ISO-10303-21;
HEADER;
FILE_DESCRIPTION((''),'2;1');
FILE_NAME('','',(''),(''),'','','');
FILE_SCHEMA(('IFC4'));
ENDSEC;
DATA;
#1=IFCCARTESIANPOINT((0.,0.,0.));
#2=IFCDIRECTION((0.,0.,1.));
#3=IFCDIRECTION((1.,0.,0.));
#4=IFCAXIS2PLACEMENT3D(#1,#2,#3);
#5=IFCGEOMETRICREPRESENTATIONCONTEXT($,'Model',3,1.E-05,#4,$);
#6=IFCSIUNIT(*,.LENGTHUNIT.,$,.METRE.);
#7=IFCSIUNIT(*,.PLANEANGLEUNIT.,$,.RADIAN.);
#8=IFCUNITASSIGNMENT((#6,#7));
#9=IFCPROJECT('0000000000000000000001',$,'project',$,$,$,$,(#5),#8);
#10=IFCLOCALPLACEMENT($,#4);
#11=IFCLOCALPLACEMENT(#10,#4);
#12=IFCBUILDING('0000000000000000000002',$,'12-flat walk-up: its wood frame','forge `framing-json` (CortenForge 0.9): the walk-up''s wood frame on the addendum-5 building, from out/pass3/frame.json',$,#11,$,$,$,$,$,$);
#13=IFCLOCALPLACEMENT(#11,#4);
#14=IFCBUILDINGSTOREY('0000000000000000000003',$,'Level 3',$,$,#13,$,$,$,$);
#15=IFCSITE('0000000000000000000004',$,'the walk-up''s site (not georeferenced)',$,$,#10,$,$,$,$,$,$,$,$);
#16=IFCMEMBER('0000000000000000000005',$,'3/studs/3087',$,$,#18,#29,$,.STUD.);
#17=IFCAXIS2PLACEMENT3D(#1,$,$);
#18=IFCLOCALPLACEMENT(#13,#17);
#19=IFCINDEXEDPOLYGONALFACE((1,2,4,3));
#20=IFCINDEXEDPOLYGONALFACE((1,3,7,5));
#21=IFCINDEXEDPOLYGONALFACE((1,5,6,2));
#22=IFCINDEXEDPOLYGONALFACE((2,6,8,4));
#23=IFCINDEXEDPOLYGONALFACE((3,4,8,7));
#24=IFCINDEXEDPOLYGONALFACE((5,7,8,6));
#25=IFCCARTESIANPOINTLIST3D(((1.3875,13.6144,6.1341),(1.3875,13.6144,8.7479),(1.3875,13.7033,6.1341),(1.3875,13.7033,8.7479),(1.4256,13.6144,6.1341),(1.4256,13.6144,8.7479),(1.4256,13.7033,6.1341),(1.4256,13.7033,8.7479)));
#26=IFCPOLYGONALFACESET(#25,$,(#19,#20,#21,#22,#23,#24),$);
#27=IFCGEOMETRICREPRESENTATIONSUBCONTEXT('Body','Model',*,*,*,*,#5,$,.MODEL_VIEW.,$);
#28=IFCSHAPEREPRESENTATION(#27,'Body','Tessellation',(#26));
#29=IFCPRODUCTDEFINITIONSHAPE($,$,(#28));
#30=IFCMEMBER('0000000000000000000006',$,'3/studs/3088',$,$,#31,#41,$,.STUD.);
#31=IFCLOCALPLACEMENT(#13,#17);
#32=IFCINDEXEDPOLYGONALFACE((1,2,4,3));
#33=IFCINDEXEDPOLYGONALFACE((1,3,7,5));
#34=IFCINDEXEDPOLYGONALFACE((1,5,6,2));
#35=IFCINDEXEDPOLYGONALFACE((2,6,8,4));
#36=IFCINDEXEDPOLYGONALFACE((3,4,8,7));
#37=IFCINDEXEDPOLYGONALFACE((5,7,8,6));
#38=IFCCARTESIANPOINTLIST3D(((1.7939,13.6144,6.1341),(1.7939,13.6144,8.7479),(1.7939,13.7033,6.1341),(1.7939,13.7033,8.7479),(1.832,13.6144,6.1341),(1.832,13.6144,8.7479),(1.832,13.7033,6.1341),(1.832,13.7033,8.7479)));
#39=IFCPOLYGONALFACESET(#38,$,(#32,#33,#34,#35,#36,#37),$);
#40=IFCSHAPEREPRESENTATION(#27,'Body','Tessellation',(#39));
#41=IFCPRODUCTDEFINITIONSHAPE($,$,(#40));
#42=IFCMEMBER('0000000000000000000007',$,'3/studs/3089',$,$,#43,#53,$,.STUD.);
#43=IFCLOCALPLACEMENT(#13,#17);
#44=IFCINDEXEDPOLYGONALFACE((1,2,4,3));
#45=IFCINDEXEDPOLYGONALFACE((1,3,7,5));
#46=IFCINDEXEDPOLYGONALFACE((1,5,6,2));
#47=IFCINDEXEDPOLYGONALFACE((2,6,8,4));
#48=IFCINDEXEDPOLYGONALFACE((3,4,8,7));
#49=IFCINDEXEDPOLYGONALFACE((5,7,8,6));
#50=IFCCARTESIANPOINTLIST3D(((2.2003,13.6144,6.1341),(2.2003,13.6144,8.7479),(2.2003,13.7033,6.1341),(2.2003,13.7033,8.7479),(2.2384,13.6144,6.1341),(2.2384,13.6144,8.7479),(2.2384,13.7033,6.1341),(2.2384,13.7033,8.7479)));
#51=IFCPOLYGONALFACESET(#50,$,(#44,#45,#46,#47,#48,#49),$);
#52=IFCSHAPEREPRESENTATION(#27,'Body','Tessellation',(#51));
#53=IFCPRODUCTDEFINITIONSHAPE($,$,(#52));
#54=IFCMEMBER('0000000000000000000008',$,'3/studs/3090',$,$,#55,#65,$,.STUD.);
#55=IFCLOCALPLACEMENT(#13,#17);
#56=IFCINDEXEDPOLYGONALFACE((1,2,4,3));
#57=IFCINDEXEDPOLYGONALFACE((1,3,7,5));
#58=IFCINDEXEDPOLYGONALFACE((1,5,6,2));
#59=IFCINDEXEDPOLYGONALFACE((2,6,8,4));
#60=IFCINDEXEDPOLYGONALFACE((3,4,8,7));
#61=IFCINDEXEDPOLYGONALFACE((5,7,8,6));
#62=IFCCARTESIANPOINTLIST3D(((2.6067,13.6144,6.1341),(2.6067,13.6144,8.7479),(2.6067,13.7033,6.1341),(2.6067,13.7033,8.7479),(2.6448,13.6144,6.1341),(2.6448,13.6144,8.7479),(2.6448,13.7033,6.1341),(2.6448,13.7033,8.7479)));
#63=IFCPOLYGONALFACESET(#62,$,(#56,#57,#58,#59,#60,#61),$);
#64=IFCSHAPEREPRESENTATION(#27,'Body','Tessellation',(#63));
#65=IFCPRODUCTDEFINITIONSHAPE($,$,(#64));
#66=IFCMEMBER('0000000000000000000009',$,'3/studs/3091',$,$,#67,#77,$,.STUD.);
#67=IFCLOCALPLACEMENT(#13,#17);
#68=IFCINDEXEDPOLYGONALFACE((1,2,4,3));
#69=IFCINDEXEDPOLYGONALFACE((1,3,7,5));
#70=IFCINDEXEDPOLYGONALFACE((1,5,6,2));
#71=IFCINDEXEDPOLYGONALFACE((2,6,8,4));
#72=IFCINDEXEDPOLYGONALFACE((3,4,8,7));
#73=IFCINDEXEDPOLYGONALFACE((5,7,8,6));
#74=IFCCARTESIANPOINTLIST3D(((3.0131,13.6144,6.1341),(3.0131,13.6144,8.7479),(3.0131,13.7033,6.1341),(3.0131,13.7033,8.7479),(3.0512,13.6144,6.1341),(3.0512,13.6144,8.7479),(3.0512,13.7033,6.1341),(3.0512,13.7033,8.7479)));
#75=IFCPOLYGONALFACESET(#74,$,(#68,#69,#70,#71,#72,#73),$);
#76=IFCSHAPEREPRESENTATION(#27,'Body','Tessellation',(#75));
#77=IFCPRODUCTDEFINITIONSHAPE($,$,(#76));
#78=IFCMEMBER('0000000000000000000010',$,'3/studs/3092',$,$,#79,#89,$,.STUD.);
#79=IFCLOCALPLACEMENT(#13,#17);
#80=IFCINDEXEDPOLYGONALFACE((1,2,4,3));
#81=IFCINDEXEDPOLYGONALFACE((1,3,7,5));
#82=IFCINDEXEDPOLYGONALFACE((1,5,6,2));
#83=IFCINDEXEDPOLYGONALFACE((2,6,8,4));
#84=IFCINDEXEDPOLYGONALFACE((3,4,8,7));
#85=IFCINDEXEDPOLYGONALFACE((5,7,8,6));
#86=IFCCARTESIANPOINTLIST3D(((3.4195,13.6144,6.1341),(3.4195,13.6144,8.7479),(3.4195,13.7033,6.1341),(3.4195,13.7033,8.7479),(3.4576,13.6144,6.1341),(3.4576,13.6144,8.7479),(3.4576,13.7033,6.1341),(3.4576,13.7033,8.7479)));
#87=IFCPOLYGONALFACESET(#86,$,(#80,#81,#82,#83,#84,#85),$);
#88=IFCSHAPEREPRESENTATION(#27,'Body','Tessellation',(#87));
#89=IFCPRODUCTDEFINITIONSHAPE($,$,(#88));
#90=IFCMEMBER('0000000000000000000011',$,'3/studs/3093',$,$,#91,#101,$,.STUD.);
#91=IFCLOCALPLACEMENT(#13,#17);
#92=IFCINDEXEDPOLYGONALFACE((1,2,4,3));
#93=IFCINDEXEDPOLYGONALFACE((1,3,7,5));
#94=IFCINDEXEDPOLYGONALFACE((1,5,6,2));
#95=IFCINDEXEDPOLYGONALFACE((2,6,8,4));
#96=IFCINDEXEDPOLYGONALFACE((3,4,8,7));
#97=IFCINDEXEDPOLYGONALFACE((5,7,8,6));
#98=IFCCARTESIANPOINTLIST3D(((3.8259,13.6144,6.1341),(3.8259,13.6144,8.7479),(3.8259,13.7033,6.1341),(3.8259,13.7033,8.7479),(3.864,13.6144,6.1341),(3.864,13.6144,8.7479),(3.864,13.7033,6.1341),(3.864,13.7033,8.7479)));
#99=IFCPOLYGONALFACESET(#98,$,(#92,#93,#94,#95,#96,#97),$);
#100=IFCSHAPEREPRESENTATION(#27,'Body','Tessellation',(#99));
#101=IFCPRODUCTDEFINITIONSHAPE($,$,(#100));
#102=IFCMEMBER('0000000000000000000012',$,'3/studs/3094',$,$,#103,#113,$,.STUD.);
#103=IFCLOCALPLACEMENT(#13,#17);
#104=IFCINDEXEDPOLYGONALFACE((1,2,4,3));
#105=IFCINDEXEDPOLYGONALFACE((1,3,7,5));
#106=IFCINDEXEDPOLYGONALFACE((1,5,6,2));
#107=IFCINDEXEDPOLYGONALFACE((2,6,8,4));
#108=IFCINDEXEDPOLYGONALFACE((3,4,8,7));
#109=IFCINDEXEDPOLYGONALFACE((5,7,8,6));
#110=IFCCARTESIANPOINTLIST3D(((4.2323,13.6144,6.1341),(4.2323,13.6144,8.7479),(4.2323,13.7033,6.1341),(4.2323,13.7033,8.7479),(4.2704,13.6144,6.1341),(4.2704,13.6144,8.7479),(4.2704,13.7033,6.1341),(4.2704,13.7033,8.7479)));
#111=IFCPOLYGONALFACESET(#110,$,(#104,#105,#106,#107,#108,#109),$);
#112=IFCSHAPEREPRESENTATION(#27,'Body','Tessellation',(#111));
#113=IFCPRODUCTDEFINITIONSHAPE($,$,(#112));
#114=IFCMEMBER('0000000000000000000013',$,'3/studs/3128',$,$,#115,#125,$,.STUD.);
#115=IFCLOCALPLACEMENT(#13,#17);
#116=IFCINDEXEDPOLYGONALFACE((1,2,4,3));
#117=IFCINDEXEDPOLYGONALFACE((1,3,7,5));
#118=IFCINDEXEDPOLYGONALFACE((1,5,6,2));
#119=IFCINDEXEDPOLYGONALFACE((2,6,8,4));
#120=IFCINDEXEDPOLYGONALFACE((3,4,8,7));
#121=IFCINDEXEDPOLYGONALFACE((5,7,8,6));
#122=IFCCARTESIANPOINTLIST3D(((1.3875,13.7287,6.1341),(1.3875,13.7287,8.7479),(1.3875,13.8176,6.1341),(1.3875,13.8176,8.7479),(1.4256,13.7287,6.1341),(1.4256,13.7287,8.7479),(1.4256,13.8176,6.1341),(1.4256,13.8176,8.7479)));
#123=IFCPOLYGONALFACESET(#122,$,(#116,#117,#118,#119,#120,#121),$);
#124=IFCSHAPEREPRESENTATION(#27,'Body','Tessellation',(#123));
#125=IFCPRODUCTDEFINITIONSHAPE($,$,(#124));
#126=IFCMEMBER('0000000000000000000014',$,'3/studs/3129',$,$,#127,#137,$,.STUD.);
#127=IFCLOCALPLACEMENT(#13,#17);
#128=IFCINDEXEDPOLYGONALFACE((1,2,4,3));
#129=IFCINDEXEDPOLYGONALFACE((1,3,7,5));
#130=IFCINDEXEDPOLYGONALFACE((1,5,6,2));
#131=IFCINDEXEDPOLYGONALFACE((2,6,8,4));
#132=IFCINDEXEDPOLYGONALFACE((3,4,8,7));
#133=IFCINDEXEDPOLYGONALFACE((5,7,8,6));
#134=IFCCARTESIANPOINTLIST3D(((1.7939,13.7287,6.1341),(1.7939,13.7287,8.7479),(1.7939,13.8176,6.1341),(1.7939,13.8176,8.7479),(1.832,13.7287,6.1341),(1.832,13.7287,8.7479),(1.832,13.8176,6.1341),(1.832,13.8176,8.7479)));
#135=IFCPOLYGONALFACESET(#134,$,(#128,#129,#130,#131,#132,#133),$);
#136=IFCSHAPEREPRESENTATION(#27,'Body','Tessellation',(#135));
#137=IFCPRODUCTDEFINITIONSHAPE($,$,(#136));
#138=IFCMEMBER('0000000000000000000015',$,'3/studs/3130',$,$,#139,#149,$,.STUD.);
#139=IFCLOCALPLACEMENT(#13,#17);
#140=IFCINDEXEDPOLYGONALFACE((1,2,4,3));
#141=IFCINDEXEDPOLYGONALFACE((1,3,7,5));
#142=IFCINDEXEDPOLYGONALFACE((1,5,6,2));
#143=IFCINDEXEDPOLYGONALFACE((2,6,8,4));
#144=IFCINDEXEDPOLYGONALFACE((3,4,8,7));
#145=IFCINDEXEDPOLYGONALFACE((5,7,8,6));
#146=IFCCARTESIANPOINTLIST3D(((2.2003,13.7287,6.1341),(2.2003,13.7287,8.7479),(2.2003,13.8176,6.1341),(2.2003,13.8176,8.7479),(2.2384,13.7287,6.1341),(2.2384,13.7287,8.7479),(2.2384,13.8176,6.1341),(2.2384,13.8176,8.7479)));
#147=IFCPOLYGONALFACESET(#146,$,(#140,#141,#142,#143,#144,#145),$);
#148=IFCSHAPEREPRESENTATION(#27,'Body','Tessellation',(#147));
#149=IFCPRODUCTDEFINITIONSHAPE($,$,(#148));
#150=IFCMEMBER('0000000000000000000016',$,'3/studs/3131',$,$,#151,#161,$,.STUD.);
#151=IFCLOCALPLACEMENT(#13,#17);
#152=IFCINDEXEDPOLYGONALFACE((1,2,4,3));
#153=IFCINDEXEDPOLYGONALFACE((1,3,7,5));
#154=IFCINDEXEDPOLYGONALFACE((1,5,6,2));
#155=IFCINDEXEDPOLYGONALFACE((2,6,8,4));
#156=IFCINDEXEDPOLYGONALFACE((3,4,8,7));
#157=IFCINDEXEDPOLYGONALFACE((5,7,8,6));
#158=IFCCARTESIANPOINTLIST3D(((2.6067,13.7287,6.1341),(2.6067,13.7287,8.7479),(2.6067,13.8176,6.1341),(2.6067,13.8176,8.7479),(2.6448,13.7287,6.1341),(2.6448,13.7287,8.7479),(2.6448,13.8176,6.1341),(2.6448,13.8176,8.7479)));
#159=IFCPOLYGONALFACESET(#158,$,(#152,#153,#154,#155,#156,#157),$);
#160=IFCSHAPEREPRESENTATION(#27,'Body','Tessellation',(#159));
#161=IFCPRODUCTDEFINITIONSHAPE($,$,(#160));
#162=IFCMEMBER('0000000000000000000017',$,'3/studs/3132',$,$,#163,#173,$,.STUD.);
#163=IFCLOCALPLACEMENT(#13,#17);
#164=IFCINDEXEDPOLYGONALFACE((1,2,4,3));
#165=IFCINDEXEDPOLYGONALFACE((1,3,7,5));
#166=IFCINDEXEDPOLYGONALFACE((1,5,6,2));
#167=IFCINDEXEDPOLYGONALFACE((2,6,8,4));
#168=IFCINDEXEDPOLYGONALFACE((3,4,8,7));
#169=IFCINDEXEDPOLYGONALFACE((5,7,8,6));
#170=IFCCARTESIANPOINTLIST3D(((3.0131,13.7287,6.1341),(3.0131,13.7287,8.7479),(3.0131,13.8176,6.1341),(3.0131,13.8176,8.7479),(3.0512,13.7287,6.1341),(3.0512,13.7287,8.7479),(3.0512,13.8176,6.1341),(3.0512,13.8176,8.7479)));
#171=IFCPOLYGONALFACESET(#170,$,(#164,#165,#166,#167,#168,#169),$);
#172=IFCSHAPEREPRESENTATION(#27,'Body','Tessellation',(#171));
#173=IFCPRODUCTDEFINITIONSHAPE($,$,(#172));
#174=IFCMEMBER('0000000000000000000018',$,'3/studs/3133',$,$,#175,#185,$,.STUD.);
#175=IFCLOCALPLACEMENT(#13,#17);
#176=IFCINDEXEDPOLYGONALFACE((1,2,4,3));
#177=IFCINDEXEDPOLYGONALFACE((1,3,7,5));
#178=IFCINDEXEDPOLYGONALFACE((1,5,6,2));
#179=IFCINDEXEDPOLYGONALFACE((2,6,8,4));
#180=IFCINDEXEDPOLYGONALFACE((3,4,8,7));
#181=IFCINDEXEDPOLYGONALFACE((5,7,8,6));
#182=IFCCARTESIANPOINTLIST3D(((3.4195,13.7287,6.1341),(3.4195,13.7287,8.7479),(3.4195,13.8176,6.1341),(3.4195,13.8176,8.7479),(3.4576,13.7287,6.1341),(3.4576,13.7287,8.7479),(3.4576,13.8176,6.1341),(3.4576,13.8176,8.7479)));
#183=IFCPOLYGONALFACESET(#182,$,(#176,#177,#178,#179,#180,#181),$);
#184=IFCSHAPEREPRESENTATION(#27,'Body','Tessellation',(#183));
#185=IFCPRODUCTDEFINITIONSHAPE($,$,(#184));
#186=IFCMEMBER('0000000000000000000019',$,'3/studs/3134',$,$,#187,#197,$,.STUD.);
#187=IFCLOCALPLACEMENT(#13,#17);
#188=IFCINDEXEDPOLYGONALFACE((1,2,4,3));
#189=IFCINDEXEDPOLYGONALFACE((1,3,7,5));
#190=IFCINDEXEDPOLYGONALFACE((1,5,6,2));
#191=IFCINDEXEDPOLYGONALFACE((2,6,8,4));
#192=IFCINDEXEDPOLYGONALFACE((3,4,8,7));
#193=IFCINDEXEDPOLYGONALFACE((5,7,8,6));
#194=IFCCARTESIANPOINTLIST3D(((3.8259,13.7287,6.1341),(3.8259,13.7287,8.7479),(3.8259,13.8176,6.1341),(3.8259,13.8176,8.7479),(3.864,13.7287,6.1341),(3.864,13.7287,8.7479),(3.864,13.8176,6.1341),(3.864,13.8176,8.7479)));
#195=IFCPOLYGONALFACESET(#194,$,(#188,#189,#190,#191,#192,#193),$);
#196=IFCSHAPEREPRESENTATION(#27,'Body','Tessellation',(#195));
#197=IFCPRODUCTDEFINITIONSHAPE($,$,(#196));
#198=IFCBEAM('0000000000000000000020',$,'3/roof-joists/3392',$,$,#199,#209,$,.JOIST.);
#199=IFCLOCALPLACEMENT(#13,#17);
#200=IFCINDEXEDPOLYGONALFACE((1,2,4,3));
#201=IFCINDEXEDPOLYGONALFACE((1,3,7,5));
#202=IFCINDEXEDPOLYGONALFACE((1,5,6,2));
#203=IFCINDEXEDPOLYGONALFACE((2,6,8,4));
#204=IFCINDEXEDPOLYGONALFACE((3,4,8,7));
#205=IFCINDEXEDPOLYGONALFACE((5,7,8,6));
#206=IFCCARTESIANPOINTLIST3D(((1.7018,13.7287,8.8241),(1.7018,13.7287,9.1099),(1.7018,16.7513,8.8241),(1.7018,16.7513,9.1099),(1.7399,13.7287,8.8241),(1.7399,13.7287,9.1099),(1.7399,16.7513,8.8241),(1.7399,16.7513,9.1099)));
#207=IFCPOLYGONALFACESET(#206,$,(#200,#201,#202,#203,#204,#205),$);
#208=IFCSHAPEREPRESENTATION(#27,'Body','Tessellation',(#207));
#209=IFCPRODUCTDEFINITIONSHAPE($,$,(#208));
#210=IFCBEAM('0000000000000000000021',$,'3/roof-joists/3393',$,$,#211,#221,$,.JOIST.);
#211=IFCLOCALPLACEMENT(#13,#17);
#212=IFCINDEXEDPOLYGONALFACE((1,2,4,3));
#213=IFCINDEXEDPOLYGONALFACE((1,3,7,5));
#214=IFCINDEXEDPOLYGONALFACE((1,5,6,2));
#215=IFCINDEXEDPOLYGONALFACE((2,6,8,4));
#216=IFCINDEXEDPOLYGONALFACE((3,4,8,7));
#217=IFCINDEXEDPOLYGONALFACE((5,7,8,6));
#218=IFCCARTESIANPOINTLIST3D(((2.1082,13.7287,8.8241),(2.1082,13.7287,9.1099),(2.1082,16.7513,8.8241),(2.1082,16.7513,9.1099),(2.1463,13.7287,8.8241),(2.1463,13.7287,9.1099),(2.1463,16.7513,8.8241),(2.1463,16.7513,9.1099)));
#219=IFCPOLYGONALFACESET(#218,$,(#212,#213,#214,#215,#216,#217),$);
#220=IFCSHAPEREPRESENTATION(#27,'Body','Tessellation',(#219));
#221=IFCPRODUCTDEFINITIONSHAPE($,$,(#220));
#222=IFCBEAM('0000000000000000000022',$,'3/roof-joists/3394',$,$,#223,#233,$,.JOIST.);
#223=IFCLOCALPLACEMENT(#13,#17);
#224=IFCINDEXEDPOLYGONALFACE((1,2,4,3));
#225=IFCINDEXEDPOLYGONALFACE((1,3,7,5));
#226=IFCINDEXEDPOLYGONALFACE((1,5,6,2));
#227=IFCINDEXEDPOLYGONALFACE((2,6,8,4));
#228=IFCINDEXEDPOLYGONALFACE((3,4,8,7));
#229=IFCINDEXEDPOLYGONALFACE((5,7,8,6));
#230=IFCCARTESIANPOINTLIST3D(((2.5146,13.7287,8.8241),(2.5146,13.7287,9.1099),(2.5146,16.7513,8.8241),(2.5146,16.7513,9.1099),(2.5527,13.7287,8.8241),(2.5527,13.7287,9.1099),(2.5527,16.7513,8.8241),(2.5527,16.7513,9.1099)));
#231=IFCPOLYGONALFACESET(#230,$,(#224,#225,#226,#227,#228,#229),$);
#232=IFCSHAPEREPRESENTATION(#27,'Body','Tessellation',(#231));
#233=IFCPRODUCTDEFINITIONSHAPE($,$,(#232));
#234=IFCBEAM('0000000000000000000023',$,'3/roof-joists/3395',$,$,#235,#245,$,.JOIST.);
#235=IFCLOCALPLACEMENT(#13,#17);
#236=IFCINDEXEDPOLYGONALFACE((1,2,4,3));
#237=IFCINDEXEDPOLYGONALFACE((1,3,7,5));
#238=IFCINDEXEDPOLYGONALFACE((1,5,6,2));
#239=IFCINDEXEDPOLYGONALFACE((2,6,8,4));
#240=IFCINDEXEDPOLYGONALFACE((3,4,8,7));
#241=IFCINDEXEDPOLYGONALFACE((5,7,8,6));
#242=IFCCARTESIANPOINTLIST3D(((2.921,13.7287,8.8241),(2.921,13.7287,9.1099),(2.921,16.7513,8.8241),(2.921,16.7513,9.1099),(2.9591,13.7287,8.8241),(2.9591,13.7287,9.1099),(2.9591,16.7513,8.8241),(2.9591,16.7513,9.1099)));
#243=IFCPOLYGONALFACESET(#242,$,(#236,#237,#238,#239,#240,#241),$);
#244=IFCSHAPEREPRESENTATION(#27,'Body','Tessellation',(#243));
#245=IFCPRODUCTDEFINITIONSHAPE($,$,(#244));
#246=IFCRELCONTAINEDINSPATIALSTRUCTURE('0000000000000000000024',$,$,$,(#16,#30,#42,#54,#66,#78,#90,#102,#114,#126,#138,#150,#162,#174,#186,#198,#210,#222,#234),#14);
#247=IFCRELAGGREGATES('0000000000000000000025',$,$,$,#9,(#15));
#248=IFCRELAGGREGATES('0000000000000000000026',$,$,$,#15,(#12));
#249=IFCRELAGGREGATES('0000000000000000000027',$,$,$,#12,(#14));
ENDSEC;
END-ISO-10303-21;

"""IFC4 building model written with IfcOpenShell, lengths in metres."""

from ifc_helpers import new_model, si_unit, frame, frame_2d, origin, origin_with_axes, place, context, subcontext, project, spatial, rectangle, extrude, element, save


model = new_model("IFC4")

# Units and contexts
model_context = context("Model", 3, precision=1e-05, world=origin_with_axes())
body_context = subcontext(model_context, "Body", "Model", "MODEL_VIEW")
ifc_project = project(units=[si_unit("LENGTHUNIT", "METRE"), si_unit("PLANEANGLEUNIT", "RADIAN")], contexts=[model_context])

# Site, building, storey
site_placement = place(None, origin_with_axes())
site = spatial("IfcSite", under=ifc_project, at=site_placement, Name="the walk-up's site (not georeferenced)")
building_placement = place(site_placement, origin_with_axes())
building = spatial("IfcBuilding", under=site, at=building_placement, Name="12-flat walk-up: its wood frame", Description="forge `framing-json` (CortenForge 0.9): the walk-up's wood frame on the addendum-5 building, from out/pass3/frame.json")
storey_placement = place(building_placement, origin_with_axes())
storey = spatial("IfcBuildingStorey", under=building, at=storey_placement, Name="Level 3")

# Members
member_1_placement = place(storey_placement, frame((1.3875, 13.6144, 6.1341), z_axis=(0.0, 0.0, 1.0), x_axis=(1.0, 0.0, 0.0)))
element("IfcMember", 1, at=member_1_placement, inside=storey, Name="3/studs/3087", PredefinedType="STUD", context=body_context, shape_type="SweptSolid", body=[
    extrude(rectangle(XDim=0.0381, YDim=0.0889, at=frame_2d((0.0191, 0.0445))), origin(), (0.0, 0.0, 1.0), 2.6138),
])
member_2_placement = place(storey_placement, frame((1.7939, 13.6144, 6.1341), z_axis=(0.0, 0.0, 1.0), x_axis=(1.0, 0.0, 0.0)))
element("IfcMember", 2, at=member_2_placement, inside=storey, Name="3/studs/3088", PredefinedType="STUD", context=body_context, shape_type="SweptSolid", body=[
    extrude(rectangle(XDim=0.0381, YDim=0.0889, at=frame_2d((0.019, 0.0445))), origin(), (0.0, 0.0, 1.0), 2.6138),
])
for number, where, z_axis, x_axis, name in (
    (3, (2.2003, 13.6144, 6.1341), (0.0, 0.0, 1.0), (1.0, 0.0, 0.0), "3/studs/3089"),
    (4, (2.6067, 13.6144, 6.1341), (0.0, 0.0, 1.0), (1.0, 0.0, 0.0), "3/studs/3090"),
    (5, (3.0131, 13.6144, 6.1341), (0.0, 0.0, 1.0), (1.0, 0.0, 0.0), "3/studs/3091"),
    (6, (3.4195, 13.6144, 6.1341), (0.0, 0.0, 1.0), (1.0, 0.0, 0.0), "3/studs/3092"),
    (7, (3.8259, 13.6144, 6.1341), (0.0, 0.0, 1.0), (1.0, 0.0, 0.0), "3/studs/3093"),
    (8, (4.2323, 13.6144, 6.1341), (0.0, 0.0, 1.0), (1.0, 0.0, 0.0), "3/studs/3094"),
    (9, (1.3875, 13.7287, 6.1341), (0.0, 0.0, 1.0), (1.0, 0.0, 0.0), "3/studs/3128"),
):
    element("IfcMember", number, at=place(storey_placement, frame(where, z_axis=z_axis, x_axis=x_axis)), inside=storey, Name=name, PredefinedType="STUD", context=body_context, shape_type="SweptSolid", body=[
        extrude(rectangle(XDim=0.0381, YDim=0.0889, at=frame_2d((0.0191, 0.0445))), origin(), (0.0, 0.0, 1.0), 2.6138),
    ])
member_3_placement = place(storey_placement, frame((1.7939, 13.7287, 6.1341), z_axis=(0.0, 0.0, 1.0), x_axis=(1.0, 0.0, 0.0)))
element("IfcMember", 10, at=member_3_placement, inside=storey, Name="3/studs/3129", PredefinedType="STUD", context=body_context, shape_type="SweptSolid", body=[
    extrude(rectangle(XDim=0.0381, YDim=0.0889, at=frame_2d((0.019, 0.0445))), origin(), (0.0, 0.0, 1.0), 2.6138),
])
for number, where, z_axis, x_axis, name in (
    (11, (2.2003, 13.7287, 6.1341), (0.0, 0.0, 1.0), (1.0, 0.0, 0.0), "3/studs/3130"),
    (12, (2.6067, 13.7287, 6.1341), (0.0, 0.0, 1.0), (1.0, 0.0, 0.0), "3/studs/3131"),
    (13, (3.0131, 13.7287, 6.1341), (0.0, 0.0, 1.0), (1.0, 0.0, 0.0), "3/studs/3132"),
    (14, (3.4195, 13.7287, 6.1341), (0.0, 0.0, 1.0), (1.0, 0.0, 0.0), "3/studs/3133"),
    (15, (3.8259, 13.7287, 6.1341), (0.0, 0.0, 1.0), (1.0, 0.0, 0.0), "3/studs/3134"),
):
    element("IfcMember", number, at=place(storey_placement, frame(where, z_axis=z_axis, x_axis=x_axis)), inside=storey, Name=name, PredefinedType="STUD", context=body_context, shape_type="SweptSolid", body=[
        extrude(rectangle(XDim=0.0381, YDim=0.0889, at=frame_2d((0.0191, 0.0445))), origin(), (0.0, 0.0, 1.0), 2.6138),
    ])

# Beams
for number, where, z_axis, x_axis, name in (
    (16, (1.7018, 13.7287, 8.8241), (0.0, 0.0, 1.0), (1.0, 0.0, 0.0), "3/roof-joists/3392"),
    (17, (2.1082, 13.7287, 8.8241), (0.0, 0.0, 1.0), (1.0, 0.0, 0.0), "3/roof-joists/3393"),
    (18, (2.5146, 13.7287, 8.8241), (0.0, 0.0, 1.0), (1.0, 0.0, 0.0), "3/roof-joists/3394"),
    (19, (2.921, 13.7287, 8.8241), (0.0, 0.0, 1.0), (1.0, 0.0, 0.0), "3/roof-joists/3395"),
):
    element("IfcBeam", number, at=place(storey_placement, frame(where, z_axis=z_axis, x_axis=x_axis)), inside=storey, Name=name, PredefinedType="JOIST", context=body_context, shape_type="SweptSolid", body=[
        extrude(rectangle(XDim=0.0381, YDim=3.0226, at=frame_2d((0.0191, 1.5113))), origin(), (0.0, 0.0, 1.0), 0.2858),
    ])

save(model, "model.ifc")
